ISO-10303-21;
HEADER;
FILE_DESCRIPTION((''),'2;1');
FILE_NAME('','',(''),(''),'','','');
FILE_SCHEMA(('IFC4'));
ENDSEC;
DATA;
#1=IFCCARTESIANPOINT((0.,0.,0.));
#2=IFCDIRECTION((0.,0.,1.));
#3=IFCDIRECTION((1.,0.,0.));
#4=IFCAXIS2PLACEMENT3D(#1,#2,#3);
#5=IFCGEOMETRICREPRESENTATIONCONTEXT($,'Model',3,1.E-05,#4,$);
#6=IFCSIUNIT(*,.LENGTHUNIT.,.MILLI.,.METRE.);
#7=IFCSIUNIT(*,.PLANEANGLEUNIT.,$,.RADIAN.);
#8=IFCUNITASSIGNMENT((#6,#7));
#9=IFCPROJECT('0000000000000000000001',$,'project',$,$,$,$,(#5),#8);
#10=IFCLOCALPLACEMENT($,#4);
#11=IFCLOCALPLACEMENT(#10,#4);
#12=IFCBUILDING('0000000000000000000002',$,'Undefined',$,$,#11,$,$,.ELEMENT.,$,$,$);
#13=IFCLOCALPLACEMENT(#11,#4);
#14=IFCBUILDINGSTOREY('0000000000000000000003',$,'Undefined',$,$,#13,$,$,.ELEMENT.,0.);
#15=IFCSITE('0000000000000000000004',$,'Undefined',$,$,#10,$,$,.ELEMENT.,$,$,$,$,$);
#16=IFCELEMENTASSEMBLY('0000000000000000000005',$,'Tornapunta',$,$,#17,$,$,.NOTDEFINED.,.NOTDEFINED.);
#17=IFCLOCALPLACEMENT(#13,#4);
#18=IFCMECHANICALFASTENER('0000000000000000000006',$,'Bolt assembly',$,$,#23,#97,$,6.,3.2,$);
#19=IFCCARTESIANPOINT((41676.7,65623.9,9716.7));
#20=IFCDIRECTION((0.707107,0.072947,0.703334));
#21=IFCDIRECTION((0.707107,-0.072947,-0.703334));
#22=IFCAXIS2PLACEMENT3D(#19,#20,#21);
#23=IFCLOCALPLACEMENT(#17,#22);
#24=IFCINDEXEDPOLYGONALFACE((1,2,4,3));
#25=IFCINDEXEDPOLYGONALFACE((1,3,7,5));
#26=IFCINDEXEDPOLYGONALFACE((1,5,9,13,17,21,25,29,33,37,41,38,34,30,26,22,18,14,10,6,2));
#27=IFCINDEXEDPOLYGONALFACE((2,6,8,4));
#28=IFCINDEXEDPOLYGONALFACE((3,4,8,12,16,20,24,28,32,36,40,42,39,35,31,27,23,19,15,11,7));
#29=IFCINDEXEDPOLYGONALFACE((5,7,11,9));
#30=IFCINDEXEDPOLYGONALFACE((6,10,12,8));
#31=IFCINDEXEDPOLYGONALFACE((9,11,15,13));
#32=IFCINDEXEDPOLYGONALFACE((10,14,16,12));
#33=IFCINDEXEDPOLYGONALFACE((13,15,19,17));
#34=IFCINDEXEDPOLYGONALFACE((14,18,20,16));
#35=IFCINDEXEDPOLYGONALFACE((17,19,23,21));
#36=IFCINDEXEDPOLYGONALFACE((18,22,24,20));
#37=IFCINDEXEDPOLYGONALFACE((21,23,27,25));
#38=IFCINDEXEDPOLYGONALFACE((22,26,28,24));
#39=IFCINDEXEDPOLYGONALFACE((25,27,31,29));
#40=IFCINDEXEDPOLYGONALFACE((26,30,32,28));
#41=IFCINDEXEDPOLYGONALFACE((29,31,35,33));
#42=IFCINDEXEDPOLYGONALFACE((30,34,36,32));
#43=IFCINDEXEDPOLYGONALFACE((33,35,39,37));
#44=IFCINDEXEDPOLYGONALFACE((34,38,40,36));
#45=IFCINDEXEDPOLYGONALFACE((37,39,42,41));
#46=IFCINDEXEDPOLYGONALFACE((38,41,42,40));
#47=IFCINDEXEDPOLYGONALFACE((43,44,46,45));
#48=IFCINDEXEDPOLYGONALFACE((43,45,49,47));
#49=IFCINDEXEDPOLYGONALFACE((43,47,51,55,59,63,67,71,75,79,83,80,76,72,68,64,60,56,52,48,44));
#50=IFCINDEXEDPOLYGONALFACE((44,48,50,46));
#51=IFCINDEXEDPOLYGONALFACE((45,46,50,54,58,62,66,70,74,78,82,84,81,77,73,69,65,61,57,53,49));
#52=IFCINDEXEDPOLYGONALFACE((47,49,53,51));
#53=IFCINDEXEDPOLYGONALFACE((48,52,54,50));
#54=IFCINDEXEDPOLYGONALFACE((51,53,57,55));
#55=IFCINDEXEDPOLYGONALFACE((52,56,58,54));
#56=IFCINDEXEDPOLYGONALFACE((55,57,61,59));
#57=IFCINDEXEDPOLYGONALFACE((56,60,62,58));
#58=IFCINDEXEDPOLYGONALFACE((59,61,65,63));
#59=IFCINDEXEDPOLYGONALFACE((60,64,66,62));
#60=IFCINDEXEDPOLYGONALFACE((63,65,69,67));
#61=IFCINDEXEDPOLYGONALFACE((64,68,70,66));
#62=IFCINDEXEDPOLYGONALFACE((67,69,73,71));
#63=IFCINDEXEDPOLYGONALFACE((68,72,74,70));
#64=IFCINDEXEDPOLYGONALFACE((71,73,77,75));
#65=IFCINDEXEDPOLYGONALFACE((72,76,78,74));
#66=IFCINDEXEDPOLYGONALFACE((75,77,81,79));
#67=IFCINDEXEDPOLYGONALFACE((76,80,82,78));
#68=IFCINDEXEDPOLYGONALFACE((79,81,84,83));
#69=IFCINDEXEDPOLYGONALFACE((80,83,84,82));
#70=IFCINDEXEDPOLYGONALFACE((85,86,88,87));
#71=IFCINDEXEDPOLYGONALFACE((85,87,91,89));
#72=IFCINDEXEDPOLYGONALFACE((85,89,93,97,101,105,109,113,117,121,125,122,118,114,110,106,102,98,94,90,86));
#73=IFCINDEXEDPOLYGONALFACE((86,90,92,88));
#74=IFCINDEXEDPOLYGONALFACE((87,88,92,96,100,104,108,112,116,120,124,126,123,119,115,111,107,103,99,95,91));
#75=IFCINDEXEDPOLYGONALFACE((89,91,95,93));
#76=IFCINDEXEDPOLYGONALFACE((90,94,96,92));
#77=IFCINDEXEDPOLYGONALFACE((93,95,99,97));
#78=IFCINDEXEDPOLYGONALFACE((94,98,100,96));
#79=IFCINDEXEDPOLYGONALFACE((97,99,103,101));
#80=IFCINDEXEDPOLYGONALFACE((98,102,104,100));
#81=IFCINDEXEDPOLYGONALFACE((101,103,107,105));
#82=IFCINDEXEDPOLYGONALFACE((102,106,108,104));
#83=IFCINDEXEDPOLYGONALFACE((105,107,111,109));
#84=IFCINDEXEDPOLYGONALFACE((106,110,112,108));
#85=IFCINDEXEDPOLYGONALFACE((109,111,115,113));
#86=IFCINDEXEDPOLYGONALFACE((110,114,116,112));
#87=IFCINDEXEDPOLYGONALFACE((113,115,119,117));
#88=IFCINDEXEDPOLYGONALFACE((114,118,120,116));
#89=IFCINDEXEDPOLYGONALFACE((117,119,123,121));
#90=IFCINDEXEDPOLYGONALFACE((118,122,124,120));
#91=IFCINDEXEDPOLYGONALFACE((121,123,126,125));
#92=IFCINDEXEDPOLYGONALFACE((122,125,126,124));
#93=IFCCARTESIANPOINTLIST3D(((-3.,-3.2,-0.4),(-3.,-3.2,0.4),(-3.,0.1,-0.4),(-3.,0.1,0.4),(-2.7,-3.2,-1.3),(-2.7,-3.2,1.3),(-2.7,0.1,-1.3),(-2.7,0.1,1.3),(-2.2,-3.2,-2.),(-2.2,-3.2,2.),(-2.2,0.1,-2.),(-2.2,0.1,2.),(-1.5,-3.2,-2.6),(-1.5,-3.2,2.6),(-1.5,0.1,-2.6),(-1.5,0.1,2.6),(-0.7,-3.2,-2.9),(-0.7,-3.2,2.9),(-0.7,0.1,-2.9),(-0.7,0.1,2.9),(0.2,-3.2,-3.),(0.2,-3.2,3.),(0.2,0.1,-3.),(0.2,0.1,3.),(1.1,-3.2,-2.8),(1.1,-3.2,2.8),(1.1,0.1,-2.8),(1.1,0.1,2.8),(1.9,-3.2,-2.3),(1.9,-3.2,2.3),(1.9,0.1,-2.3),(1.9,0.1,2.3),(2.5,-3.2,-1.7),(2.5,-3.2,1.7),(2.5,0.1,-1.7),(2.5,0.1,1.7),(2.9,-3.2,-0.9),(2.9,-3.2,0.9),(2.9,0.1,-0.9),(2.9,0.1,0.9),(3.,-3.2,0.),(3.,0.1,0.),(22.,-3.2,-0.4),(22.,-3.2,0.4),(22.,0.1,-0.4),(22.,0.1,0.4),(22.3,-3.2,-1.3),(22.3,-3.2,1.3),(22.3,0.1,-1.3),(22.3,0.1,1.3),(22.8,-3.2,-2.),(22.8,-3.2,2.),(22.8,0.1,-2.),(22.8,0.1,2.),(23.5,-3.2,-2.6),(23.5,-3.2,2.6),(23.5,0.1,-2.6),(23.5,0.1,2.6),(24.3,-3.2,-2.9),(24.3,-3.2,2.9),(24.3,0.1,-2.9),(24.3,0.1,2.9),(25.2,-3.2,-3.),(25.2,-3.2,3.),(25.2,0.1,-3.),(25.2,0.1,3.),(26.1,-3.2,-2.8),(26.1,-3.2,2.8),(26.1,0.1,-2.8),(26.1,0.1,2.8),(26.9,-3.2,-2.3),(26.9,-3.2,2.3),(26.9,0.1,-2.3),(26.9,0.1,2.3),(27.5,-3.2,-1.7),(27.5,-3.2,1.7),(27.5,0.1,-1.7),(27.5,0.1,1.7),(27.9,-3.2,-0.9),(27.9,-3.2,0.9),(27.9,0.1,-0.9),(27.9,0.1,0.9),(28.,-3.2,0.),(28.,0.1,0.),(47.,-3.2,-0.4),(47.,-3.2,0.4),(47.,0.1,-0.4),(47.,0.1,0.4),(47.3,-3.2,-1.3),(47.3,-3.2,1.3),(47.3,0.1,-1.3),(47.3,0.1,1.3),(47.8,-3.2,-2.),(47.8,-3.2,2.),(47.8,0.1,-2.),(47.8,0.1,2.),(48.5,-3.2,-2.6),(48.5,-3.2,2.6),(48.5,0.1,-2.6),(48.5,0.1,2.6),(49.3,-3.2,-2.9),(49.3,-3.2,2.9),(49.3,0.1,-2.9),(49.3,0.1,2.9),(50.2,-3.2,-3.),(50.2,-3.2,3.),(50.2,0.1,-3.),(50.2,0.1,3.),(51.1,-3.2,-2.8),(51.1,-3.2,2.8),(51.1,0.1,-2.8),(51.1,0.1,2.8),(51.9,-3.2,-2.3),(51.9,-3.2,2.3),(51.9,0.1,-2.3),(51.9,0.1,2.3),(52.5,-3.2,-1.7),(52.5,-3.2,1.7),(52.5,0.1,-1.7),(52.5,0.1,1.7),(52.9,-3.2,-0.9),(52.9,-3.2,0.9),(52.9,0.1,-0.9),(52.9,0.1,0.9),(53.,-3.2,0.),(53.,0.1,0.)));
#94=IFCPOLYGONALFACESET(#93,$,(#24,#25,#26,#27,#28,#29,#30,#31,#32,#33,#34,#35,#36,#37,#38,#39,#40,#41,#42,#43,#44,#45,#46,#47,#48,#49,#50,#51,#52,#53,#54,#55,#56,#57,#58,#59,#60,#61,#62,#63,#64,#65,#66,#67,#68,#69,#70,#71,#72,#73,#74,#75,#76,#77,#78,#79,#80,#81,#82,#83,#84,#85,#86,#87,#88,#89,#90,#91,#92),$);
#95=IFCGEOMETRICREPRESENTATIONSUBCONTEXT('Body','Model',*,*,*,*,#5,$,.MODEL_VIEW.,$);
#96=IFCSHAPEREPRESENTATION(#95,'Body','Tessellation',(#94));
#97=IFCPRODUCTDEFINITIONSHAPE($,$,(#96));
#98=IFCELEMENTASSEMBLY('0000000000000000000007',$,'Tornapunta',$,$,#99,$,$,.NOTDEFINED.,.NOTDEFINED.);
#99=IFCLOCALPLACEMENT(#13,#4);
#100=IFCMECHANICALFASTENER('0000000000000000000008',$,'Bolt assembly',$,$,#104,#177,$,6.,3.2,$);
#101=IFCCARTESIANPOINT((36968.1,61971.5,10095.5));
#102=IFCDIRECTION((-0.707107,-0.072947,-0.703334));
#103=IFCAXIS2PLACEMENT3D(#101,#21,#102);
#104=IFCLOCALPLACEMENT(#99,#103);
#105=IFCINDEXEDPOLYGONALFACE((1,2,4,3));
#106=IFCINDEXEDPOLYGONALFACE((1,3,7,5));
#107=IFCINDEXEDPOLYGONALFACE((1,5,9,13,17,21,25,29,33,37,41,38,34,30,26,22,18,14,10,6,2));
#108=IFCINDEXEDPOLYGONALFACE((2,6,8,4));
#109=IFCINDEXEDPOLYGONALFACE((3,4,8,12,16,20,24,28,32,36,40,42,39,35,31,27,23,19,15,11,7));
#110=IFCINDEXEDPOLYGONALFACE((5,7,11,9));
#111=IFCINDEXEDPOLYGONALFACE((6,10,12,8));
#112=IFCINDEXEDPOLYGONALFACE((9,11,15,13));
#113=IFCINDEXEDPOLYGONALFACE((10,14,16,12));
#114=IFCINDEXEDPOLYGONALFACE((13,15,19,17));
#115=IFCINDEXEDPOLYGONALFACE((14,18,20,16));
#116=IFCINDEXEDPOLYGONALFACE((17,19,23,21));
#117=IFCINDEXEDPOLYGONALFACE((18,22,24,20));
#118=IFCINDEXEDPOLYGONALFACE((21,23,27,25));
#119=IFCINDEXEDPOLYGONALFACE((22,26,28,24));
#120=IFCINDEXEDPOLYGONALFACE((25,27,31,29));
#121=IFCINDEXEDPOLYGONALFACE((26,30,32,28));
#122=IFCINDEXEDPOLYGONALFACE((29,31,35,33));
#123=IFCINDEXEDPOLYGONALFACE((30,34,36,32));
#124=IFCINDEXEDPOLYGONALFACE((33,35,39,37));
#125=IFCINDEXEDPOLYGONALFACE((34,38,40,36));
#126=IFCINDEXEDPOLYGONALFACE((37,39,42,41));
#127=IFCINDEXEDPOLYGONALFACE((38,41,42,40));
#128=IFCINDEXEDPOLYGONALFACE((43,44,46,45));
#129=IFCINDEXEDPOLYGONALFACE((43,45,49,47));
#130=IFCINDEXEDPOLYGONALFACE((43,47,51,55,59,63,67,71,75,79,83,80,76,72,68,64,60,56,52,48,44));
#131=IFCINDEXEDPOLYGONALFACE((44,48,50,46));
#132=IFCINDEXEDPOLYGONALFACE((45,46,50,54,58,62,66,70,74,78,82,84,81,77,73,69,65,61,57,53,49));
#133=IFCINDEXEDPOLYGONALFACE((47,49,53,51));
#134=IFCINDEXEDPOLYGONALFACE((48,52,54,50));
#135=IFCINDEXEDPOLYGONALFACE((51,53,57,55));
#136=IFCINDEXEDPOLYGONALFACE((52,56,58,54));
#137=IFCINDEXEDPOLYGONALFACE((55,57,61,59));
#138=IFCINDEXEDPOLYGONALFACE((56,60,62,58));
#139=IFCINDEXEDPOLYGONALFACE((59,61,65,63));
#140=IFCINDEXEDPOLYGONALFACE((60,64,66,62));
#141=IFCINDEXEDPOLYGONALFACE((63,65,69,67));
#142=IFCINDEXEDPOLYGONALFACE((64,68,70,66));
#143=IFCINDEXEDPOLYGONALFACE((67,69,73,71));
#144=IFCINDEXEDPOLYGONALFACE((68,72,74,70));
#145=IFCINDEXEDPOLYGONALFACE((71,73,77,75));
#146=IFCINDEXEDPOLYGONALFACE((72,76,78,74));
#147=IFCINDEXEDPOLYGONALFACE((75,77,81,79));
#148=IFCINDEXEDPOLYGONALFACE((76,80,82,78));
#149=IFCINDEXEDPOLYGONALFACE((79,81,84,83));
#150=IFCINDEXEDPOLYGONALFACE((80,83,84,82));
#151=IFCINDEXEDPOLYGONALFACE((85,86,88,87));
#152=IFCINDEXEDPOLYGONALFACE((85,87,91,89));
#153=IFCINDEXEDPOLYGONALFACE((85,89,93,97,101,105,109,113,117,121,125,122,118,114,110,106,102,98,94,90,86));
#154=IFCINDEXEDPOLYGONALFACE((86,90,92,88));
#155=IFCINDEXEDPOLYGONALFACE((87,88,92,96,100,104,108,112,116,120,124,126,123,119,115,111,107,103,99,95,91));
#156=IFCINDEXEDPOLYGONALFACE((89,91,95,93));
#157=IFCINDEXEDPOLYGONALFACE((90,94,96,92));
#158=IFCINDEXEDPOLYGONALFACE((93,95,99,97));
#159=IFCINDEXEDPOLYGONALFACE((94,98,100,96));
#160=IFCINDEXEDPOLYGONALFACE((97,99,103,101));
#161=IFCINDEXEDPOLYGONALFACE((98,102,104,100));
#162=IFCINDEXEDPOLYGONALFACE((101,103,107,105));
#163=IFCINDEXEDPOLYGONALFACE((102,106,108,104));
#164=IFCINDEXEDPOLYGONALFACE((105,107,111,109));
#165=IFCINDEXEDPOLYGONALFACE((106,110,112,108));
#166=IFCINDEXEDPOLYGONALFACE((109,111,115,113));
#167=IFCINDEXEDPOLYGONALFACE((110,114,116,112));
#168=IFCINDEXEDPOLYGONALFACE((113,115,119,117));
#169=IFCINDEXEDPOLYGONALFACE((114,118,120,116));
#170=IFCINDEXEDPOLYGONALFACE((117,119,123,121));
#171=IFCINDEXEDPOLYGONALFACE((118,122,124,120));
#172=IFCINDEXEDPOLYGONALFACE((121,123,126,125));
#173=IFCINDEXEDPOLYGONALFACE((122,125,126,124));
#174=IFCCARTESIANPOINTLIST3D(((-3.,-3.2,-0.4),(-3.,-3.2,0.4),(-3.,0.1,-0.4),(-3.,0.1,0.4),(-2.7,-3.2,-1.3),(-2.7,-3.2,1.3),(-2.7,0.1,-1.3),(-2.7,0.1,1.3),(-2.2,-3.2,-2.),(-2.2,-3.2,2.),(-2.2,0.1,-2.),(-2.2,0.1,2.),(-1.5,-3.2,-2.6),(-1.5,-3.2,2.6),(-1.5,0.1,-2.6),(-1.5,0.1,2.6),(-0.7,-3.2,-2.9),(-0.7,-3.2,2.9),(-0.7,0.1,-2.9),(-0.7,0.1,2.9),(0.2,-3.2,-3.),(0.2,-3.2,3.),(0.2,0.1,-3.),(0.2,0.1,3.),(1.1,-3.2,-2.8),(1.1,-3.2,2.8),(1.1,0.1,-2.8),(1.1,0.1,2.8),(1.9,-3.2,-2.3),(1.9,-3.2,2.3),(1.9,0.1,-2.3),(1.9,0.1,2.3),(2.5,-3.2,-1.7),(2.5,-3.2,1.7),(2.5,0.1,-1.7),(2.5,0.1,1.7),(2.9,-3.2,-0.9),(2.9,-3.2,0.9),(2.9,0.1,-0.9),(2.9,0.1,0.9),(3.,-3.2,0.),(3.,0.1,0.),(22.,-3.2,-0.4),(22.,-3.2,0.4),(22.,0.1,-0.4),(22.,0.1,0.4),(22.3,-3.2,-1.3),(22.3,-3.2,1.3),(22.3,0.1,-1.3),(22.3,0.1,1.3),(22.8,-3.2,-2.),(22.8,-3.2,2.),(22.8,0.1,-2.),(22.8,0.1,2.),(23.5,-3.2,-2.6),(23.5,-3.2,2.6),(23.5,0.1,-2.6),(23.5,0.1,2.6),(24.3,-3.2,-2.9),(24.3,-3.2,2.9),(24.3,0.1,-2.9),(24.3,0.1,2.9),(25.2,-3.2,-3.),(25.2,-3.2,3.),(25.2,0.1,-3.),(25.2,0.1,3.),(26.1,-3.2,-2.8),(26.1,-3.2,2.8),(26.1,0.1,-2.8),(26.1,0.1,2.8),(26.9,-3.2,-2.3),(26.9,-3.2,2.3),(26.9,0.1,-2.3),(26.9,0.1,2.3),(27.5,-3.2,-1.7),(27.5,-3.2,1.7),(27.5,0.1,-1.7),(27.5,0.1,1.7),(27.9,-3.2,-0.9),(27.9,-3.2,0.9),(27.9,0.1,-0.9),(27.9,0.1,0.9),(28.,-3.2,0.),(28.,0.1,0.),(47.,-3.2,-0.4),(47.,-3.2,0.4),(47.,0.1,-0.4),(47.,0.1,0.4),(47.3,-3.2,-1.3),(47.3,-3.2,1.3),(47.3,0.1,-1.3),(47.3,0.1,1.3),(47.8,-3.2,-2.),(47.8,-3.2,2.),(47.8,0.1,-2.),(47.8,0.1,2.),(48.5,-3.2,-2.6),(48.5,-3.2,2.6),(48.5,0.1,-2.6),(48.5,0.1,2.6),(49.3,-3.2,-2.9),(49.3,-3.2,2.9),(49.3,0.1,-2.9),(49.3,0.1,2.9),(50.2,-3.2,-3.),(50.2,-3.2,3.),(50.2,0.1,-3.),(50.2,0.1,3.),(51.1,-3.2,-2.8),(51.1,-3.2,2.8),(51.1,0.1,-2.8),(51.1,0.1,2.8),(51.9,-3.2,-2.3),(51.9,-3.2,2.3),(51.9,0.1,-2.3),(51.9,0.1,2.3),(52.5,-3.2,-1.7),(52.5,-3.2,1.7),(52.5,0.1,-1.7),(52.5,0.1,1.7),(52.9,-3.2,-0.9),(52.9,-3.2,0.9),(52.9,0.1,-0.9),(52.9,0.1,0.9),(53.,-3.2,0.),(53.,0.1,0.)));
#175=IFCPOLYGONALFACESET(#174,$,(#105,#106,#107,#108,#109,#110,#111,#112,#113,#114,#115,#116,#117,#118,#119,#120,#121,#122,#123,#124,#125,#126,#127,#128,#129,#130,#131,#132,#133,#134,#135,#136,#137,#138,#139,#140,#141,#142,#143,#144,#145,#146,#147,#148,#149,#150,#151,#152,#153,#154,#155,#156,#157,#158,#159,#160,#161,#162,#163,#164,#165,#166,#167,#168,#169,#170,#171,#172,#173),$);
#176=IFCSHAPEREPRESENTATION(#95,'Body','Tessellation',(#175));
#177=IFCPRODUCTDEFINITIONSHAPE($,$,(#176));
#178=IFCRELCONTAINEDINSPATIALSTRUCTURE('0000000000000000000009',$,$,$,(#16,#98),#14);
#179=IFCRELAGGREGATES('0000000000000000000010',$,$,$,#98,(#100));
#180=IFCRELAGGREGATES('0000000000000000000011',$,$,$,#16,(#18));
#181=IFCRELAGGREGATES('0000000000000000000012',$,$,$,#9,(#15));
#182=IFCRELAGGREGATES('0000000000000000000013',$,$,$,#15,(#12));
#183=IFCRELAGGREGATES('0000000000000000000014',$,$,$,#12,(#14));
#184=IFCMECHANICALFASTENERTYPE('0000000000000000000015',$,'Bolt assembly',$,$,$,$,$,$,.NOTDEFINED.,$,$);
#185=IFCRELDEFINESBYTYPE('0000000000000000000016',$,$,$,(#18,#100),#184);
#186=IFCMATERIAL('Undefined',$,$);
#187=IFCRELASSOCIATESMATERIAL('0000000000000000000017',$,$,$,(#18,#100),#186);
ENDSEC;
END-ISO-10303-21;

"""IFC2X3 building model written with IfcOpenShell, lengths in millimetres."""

from ifc_helpers import new_model, si_unit, frame, origin_with_axes, origin_2d_with_axis, place, context, subcontext, project, spatial, circle, extrude, source, transform, mapped, material, type_object, element, aggregate, save


model = new_model("IFC2X3")

# Units and contexts
model_context = context("Model", 3, precision=1e-05, world=origin_with_axes())
body_context = subcontext(model_context, "Body", "Model", "MODEL_VIEW")
ifc_project = project(units=[si_unit("LENGTHUNIT", "METRE", prefix="MILLI"), si_unit("PLANEANGLEUNIT", "RADIAN")], contexts=[model_context])

# Site, building, storey
site_placement = place(None, origin_with_axes())
site = spatial("IfcSite", under=ifc_project, at=site_placement, Name="Undefined", CompositionType="ELEMENT")
building_placement = place(site_placement, origin_with_axes())
building = spatial("IfcBuilding", under=site, at=building_placement, Name="Undefined", CompositionType="ELEMENT")
storey_placement = place(building_placement, origin_with_axes())
storey = spatial("IfcBuildingStorey", under=building, at=storey_placement, Name="Undefined", CompositionType="ELEMENT", Elevation=0.0)

# Element assembly
assembly_1_placement = place(storey_placement, origin_with_axes())
assembly_1 = element("IfcElementAssembly", 1, at=assembly_1_placement, inside=storey, Name="Tornapunta", AssemblyPlace="NOTDEFINED", PredefinedType="NOTDEFINED")

# Shared definitions
ifc_material_1 = material(Name="Undefined")
mechanical_fastener_type = type_object("IfcMechanicalFastenerType", Name="Bolt assembly")
shared_shape_1 = source(origin_with_axes(), body_context, "Body", "SweptSolid", [
    extrude(circle(Radius=3.0, at=origin_2d_with_axis()), frame((0.0, -3.2, 0.0), z_axis=(0.0, 1.0, 0.0), x_axis=(1.0, 0.0, 0.0)), (0.0, 0.0, 1.0), 3.3),
])

# Mechanical fastener
mechanical_fastener_1_placement = place(assembly_1_placement, frame((41676.7, 65623.9, 9716.7), z_axis=(0.707107, 0.072947, 0.703334), x_axis=(0.707107, -0.072947, -0.703334)))
mechanical_fastener_1 = element("IfcMechanicalFastener", 2, at=mechanical_fastener_1_placement, type_object=mechanical_fastener_type, material=ifc_material_1, Name="Bolt assembly", NominalDiameter=6.0, NominalLength=3.2, context=body_context, shape_type="MappedRepresentation", body=[
    mapped(shared_shape_1, transform((0.0, 0.0, 0.0))),
    mapped(shared_shape_1, transform((25.0, 0.0, 0.0))),
    mapped(shared_shape_1, transform((50.0, 0.0, 0.0))),
])

# Element assembly, mechanical fastener
assembly_2_placement = place(storey_placement, origin_with_axes())
assembly_2 = element("IfcElementAssembly", 3, at=assembly_2_placement, inside=storey, Name="Tornapunta", AssemblyPlace="NOTDEFINED", PredefinedType="NOTDEFINED")
mechanical_fastener_2_placement = place(assembly_2_placement, frame((36968.1, 61971.5, 10095.5), z_axis=(0.707107, -0.072947, -0.703334), x_axis=(-0.707107, -0.072947, -0.703334)))
mechanical_fastener_2 = element("IfcMechanicalFastener", 4, at=mechanical_fastener_2_placement, type_object=mechanical_fastener_type, material=ifc_material_1, Name="Bolt assembly", NominalDiameter=6.0, NominalLength=3.2, context=body_context, shape_type="MappedRepresentation", body=[
    mapped(shared_shape_1, transform((0.0, 0.0, 0.0))),
    mapped(shared_shape_1, transform((25.0, 0.0, 0.0))),
    mapped(shared_shape_1, transform((50.0, 0.0, 0.0))),
])
aggregate(assembly_2, [mechanical_fastener_2])

aggregate(assembly_1, [mechanical_fastener_1])

save(model, "model.ifc")
